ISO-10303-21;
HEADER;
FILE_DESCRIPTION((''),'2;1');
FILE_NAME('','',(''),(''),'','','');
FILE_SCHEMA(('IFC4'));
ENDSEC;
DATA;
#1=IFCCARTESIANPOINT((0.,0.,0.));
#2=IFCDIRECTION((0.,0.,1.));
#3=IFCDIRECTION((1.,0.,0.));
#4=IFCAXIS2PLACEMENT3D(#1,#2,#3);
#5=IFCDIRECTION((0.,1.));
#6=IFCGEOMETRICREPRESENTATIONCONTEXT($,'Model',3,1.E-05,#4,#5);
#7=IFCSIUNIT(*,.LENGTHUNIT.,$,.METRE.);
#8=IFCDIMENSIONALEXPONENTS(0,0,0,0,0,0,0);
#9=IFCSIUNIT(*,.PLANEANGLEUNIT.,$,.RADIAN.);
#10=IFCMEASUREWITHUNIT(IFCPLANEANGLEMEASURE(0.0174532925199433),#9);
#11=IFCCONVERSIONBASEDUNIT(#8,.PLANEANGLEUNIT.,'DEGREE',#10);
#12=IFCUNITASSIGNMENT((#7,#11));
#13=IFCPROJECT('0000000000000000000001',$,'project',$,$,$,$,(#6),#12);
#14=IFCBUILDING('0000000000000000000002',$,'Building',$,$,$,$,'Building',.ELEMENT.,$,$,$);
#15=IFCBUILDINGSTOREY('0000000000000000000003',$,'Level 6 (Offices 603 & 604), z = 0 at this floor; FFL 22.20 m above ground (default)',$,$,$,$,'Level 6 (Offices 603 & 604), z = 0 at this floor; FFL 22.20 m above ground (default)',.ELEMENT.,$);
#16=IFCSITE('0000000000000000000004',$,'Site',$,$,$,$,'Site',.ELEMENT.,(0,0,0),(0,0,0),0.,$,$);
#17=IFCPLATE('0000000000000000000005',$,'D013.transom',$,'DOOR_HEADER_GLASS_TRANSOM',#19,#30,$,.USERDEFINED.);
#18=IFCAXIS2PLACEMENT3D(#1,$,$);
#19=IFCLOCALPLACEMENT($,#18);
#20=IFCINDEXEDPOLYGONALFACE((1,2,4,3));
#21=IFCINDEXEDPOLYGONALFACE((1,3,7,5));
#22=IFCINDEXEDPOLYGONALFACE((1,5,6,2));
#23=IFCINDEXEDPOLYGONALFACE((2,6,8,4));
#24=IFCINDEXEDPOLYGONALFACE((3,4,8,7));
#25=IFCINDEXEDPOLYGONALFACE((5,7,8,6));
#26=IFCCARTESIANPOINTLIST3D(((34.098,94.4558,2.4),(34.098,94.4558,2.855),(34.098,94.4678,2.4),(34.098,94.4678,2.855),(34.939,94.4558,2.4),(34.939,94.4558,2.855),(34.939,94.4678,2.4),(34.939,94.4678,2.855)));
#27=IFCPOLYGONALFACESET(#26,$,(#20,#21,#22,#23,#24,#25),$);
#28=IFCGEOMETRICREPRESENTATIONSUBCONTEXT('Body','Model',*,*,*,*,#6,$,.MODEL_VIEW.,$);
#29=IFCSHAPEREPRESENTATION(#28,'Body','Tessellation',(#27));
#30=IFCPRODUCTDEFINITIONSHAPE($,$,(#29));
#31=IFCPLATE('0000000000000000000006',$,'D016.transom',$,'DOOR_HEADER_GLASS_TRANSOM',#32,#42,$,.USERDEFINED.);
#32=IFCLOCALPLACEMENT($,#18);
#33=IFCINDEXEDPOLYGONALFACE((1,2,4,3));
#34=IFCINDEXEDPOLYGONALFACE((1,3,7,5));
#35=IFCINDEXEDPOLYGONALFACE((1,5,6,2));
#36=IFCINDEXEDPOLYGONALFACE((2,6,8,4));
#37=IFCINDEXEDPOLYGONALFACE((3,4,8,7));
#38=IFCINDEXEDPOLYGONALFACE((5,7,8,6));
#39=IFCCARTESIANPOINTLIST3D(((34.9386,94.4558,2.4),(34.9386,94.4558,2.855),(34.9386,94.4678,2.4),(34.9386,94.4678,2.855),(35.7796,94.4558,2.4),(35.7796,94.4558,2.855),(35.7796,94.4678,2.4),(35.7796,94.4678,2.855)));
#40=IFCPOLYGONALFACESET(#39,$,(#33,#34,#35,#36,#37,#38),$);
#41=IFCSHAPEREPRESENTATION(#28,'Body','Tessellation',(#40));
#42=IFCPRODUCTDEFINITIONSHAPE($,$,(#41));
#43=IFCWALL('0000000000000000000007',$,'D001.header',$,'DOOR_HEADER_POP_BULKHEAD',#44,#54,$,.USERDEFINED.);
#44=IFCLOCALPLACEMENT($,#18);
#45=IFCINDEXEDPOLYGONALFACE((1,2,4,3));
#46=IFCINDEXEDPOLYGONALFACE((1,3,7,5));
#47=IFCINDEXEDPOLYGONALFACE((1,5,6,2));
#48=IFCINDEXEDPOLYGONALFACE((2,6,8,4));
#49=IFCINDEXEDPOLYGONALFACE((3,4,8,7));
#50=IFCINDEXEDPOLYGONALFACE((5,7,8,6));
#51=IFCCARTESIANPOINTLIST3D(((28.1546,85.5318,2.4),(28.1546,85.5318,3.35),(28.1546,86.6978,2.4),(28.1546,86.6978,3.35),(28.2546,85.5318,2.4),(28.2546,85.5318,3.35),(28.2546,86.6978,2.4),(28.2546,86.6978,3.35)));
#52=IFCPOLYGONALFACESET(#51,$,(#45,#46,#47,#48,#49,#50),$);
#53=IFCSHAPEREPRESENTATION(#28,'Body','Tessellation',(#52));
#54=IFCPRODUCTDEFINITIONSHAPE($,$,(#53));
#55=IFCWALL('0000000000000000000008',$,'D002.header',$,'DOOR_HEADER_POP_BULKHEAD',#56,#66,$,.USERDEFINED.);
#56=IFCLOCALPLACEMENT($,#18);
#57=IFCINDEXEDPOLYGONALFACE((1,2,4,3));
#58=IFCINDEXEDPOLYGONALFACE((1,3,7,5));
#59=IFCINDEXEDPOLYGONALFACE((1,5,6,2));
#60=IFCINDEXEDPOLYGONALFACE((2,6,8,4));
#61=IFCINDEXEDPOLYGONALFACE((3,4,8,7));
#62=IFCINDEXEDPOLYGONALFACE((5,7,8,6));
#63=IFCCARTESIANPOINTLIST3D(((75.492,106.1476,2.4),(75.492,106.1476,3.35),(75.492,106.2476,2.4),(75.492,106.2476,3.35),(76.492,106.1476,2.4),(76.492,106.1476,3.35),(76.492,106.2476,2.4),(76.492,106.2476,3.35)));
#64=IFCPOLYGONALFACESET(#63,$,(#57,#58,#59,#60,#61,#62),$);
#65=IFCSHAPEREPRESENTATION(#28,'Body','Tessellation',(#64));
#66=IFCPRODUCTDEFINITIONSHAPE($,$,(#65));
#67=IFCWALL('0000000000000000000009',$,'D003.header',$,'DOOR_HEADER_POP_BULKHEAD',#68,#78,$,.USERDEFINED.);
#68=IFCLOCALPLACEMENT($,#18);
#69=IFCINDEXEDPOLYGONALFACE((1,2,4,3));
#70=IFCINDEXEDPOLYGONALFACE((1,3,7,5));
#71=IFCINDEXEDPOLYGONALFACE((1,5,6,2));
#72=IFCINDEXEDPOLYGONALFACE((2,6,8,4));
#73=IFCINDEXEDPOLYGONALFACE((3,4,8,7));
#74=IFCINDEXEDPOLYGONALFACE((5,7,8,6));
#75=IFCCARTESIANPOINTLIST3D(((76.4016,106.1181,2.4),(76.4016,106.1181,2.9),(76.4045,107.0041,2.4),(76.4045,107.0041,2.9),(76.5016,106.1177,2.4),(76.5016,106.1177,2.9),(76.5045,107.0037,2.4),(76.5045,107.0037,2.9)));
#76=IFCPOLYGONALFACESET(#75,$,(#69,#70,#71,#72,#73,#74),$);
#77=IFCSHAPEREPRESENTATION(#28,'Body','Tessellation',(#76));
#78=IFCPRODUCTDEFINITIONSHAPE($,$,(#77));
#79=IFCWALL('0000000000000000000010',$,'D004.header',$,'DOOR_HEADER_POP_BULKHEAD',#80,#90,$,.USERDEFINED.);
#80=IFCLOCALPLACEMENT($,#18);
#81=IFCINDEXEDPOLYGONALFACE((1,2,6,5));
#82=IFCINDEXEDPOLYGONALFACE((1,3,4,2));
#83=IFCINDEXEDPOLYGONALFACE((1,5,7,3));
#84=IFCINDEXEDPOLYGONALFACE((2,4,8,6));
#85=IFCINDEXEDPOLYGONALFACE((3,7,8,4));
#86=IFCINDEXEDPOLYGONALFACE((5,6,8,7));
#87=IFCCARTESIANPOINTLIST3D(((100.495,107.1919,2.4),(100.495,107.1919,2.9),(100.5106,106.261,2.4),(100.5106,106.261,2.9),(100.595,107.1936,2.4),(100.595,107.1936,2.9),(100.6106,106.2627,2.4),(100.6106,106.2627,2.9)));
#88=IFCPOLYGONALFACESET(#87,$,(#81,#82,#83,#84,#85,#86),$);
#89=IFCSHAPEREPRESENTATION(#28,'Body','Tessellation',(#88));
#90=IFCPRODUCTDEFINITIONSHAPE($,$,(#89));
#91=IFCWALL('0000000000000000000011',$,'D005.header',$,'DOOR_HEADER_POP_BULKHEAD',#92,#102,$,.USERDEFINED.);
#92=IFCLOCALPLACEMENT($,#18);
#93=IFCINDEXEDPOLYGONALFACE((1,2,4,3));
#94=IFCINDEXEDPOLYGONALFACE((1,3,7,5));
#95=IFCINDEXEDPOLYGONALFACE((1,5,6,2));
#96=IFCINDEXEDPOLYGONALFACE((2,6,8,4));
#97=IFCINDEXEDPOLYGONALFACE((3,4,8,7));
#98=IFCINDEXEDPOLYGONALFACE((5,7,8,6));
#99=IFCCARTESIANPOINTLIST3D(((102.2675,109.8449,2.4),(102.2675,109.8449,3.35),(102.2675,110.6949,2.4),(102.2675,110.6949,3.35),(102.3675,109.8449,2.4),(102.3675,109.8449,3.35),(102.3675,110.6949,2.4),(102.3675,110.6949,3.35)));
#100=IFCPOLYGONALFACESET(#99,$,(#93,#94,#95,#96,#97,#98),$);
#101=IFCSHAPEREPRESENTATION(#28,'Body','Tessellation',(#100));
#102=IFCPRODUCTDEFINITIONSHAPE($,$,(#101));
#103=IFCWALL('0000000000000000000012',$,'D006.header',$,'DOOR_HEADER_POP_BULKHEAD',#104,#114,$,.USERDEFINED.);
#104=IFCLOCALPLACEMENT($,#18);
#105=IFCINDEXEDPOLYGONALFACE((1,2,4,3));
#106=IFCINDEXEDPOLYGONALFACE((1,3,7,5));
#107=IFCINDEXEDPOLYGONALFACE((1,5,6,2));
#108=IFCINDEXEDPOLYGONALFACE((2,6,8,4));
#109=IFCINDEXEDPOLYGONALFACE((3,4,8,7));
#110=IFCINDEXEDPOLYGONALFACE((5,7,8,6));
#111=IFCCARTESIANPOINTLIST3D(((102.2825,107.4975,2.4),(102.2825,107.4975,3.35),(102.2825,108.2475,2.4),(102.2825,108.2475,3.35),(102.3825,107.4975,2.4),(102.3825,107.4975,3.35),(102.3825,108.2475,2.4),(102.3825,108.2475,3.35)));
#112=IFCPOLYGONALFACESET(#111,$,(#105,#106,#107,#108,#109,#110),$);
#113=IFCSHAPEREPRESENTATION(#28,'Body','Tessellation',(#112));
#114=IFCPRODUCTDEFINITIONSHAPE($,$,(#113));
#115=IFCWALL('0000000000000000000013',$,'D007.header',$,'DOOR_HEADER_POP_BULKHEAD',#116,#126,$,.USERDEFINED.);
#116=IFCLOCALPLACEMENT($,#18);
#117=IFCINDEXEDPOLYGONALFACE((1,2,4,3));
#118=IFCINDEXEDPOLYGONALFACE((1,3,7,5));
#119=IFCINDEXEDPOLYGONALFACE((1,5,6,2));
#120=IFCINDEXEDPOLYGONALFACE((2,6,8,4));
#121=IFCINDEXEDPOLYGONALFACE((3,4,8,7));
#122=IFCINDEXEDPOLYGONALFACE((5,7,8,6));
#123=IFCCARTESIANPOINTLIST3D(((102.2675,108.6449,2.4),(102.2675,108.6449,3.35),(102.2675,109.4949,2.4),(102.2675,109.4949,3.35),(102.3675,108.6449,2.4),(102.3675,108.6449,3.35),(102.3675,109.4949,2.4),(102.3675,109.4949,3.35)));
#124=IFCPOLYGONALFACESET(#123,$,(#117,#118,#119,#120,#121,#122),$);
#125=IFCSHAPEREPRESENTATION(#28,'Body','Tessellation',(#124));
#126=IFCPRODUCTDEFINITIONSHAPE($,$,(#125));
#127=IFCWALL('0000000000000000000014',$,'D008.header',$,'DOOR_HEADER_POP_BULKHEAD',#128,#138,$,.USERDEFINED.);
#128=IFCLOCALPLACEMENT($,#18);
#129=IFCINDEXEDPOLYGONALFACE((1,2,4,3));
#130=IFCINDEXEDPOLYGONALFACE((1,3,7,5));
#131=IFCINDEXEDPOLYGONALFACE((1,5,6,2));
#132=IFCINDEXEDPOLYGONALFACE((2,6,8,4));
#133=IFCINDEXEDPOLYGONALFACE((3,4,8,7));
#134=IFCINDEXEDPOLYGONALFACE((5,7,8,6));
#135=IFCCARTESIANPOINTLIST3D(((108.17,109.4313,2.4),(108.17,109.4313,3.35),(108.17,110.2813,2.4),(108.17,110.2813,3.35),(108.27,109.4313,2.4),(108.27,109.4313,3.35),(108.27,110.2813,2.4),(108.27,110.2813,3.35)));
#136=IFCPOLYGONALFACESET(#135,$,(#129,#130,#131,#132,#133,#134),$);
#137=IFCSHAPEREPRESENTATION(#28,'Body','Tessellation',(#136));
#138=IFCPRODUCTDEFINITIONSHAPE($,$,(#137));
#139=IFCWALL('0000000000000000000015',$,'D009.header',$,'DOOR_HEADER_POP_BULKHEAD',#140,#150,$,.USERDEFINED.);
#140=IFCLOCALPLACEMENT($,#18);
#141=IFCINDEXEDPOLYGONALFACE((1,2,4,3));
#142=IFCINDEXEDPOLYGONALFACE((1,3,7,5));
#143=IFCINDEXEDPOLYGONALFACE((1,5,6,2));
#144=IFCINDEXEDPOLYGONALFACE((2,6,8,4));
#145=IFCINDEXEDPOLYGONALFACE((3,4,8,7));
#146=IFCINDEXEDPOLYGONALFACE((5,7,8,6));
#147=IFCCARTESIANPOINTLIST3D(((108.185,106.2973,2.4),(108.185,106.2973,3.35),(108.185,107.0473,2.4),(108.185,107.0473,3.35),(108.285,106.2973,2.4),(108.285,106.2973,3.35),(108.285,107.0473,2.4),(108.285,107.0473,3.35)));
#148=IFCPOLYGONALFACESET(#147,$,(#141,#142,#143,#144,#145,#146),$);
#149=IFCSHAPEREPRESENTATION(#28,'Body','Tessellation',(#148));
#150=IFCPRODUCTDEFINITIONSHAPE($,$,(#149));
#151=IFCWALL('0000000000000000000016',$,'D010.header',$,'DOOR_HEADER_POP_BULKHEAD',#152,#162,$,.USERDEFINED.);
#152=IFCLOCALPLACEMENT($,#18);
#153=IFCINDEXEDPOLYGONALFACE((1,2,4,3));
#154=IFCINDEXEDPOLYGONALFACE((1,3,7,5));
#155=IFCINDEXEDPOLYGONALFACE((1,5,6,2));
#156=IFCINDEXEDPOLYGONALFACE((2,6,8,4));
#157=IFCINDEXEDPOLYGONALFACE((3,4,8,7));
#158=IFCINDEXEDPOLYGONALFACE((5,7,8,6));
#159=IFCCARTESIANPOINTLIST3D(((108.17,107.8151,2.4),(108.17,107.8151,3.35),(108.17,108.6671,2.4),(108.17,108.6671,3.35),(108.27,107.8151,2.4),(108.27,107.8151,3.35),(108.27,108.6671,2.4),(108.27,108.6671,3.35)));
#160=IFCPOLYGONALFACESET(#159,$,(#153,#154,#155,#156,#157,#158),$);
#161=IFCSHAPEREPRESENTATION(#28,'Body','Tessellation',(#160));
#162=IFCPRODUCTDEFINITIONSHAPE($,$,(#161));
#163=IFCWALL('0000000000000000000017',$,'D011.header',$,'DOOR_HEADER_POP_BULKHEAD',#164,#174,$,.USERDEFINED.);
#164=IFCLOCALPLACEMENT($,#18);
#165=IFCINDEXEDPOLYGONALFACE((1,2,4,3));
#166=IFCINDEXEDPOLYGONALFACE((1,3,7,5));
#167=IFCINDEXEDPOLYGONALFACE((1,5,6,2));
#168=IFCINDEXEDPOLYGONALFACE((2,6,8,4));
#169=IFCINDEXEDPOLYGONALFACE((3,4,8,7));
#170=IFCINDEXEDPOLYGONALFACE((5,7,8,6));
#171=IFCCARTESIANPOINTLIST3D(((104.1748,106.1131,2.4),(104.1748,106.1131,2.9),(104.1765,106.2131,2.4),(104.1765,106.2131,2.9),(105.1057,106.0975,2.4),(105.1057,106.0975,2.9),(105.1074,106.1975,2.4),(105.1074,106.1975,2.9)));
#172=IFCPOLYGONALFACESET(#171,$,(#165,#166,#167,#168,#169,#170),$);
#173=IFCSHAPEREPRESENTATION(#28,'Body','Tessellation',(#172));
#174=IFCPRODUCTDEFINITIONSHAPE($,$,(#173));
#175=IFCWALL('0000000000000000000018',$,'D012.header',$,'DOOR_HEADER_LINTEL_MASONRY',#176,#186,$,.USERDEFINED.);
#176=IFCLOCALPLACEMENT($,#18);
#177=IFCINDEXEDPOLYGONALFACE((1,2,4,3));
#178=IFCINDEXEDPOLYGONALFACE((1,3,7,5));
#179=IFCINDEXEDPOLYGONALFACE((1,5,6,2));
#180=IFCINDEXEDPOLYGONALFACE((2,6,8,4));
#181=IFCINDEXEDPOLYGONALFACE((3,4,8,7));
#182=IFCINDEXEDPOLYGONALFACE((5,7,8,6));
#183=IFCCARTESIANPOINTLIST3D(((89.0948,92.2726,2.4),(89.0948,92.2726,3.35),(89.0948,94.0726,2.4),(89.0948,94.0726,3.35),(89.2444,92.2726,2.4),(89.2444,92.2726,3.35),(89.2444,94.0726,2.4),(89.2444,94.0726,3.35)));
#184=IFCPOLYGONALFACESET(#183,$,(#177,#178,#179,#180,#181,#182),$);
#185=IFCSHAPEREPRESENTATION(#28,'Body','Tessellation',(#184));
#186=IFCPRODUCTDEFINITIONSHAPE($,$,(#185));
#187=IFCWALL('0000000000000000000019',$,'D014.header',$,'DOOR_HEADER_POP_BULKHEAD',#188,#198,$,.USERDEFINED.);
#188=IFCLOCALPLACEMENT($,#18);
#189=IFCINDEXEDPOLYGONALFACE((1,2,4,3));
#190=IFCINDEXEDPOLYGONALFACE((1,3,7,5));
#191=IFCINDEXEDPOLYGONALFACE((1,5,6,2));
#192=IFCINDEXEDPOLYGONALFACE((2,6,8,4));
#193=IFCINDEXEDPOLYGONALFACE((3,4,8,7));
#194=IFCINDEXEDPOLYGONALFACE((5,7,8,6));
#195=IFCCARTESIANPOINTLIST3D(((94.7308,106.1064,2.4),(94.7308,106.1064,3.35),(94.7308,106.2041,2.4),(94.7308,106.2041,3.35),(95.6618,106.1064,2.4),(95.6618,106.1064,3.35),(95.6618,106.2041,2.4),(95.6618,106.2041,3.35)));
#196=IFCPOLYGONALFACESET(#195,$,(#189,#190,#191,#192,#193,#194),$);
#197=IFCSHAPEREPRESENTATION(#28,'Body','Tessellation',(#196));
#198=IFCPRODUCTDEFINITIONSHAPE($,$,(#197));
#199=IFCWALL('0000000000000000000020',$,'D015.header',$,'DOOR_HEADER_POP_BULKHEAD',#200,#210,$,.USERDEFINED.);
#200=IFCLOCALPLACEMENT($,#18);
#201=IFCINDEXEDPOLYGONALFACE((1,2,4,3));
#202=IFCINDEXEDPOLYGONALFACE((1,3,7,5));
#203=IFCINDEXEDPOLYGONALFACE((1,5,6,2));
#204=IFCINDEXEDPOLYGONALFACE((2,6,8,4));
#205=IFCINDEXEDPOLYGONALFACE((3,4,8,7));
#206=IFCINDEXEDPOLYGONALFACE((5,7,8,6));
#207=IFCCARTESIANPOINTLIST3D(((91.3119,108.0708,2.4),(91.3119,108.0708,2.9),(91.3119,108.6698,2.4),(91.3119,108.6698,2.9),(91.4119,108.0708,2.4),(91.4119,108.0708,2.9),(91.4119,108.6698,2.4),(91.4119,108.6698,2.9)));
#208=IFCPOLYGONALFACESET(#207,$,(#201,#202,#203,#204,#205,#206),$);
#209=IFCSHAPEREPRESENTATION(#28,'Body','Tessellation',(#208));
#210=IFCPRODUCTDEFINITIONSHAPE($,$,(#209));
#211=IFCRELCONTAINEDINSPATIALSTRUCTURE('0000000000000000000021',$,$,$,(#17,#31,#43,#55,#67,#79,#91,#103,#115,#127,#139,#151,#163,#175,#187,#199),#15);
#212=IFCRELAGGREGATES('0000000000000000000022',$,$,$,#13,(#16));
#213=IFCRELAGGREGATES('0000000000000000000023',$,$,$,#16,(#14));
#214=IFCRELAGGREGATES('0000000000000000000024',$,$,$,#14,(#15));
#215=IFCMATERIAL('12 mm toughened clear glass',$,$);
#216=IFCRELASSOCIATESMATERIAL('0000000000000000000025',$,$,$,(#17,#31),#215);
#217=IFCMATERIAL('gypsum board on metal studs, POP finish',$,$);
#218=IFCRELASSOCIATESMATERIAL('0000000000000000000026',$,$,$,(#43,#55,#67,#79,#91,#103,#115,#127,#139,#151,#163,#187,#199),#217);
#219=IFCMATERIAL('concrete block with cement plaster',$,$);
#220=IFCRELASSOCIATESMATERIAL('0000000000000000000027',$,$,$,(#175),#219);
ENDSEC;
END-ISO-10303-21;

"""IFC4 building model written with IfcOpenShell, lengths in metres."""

from ifc_helpers import new_model, entity, si_unit, converted_unit, direction, frame, frame_2d, origin_with_axes, origin_2d_with_axis, place, context, subcontext, project, spatial, rectangle, extrude, material, element, save


model = new_model("IFC4")

# Units and contexts
model_context = context("Model", 3, precision=1e-05, world=origin_with_axes(), true_north=direction((0.0, 1.0)))
body_context = subcontext(model_context, "Body", "Model", "MODEL_VIEW")
ifc_project = project(units=[si_unit("LENGTHUNIT", "METRE"), converted_unit("PLANEANGLEUNIT", "DEGREE", entity("IfcPlaneAngleMeasure", 0.0174532925199433), si_unit("PLANEANGLEUNIT", "RADIAN"), dimensions=[0, 0, 0, 0, 0, 0, 0])], contexts=[model_context])

# Site, building, storey
site = spatial("IfcSite", under=ifc_project, Name="Site", LongName="Site", CompositionType="ELEMENT", RefLatitude=(0, 0, 0), RefLongitude=(0, 0, 0), RefElevation=0.0)
building = spatial("IfcBuilding", under=site, Name="Building", LongName="Building", CompositionType="ELEMENT")
storey = spatial("IfcBuildingStorey", under=building, Name="Level 6 (Offices 603 & 604), z = 0 at this floor; FFL 22.20 m above ground (default)", LongName="Level 6 (Offices 603 & 604), z = 0 at this floor; FFL 22.20 m above ground (default)", CompositionType="ELEMENT")

# Plates
ifc_material_1 = material(Name="12 mm toughened clear glass")
placement = place(None, origin_with_axes())
element("IfcPlate", 1, at=placement, inside=storey, material=ifc_material_1, Name="D013.transom", ObjectType="DOOR_HEADER_GLASS_TRANSOM", PredefinedType="USERDEFINED", context=body_context, shape_type="SweptSolid", body=[
    extrude(rectangle(XDim=0.841, YDim=0.012, at=frame_2d((0.0, 0.0), x_axis=(1.0, 0.0))), frame((34.5185, 94.4618, 2.4), z_axis=(0.0, 0.0, 1.0), x_axis=(1.0, 0.0, 0.0)), (0.0, 0.0, 1.0), 0.455),
])
element("IfcPlate", 2, at=placement, inside=storey, material=ifc_material_1, Name="D016.transom", ObjectType="DOOR_HEADER_GLASS_TRANSOM", PredefinedType="USERDEFINED", context=body_context, shape_type="SweptSolid", body=[
    extrude(rectangle(XDim=0.841, YDim=0.012, at=frame_2d((0.0, 0.0), x_axis=(1.0, 0.0))), frame((35.3591, 94.4618, 2.4), z_axis=(0.0, 0.0, 1.0), x_axis=(1.0, 0.0, 0.0)), (0.0, 0.0, 1.0), 0.455),
])

# Walls
ifc_material_2 = material(Name="gypsum board on metal studs, POP finish")
element("IfcWall", 3, at=placement, inside=storey, material=ifc_material_2, Name="D001.header", ObjectType="DOOR_HEADER_POP_BULKHEAD", PredefinedType="USERDEFINED", context=body_context, shape_type="SweptSolid", body=[
    extrude(rectangle(XDim=1.166, YDim=0.1, at=frame_2d((0.0, 0.0), x_axis=(0.0, 1.0))), frame((28.2046, 86.1148, 2.4), z_axis=(0.0, 0.0, 1.0), x_axis=(1.0, 0.0, 0.0)), (0.0, 0.0, 1.0), 0.95),
])
element("IfcWall", 4, at=placement, inside=storey, material=ifc_material_2, Name="D002.header", ObjectType="DOOR_HEADER_POP_BULKHEAD", PredefinedType="USERDEFINED", context=body_context, shape_type="SweptSolid", body=[
    extrude(rectangle(XDim=1.0, YDim=0.1, at=origin_2d_with_axis()), frame((75.992, 106.1976, 2.4), z_axis=(0.0, 0.0, 1.0), x_axis=(1.0, 0.0, 0.0)), (0.0, 0.0, 1.0), 0.95),
])
element("IfcWall", 5, at=placement, inside=storey, material=ifc_material_2, Name="D003.header", ObjectType="DOOR_HEADER_POP_BULKHEAD", PredefinedType="USERDEFINED", context=body_context, shape_type="SweptSolid", body=[
    extrude(rectangle(XDim=0.886, YDim=0.1, at=frame_2d((0.0, 0.0), x_axis=(0.003275, 0.999995))), frame((76.4531, 106.5609, 2.4), z_axis=(0.0, 0.0, 1.0), x_axis=(1.0, 0.0, 0.0)), (0.0, 0.0, 1.0), 0.5),
])
element("IfcWall", 6, at=placement, inside=storey, material=ifc_material_2, Name="D004.header", ObjectType="DOOR_HEADER_POP_BULKHEAD", PredefinedType="USERDEFINED", context=body_context, shape_type="SweptSolid", body=[
    extrude(rectangle(XDim=0.931, YDim=0.1, at=frame_2d((0.0, 0.0), x_axis=(0.016765, -0.999859))), frame((100.5528, 106.7273, 2.4), z_axis=(0.0, 0.0, 1.0), x_axis=(1.0, 0.0, 0.0)), (0.0, 0.0, 1.0), 0.5),
])
element("IfcWall", 7, at=placement, inside=storey, material=ifc_material_2, Name="D005.header", ObjectType="DOOR_HEADER_POP_BULKHEAD", PredefinedType="USERDEFINED", context=body_context, shape_type="SweptSolid", body=[
    extrude(rectangle(XDim=0.85, YDim=0.1, at=frame_2d((0.0, 0.0), x_axis=(0.0, 1.0))), frame((102.3175, 110.2699, 2.4), z_axis=(0.0, 0.0, 1.0), x_axis=(1.0, 0.0, 0.0)), (0.0, 0.0, 1.0), 0.95),
])
element("IfcWall", 8, at=placement, inside=storey, material=ifc_material_2, Name="D006.header", ObjectType="DOOR_HEADER_POP_BULKHEAD", PredefinedType="USERDEFINED", context=body_context, shape_type="SweptSolid", body=[
    extrude(rectangle(XDim=0.75, YDim=0.1, at=frame_2d((0.0, 0.0), x_axis=(0.0, 1.0))), frame((102.3325, 107.8725, 2.4), z_axis=(0.0, 0.0, 1.0), x_axis=(1.0, 0.0, 0.0)), (0.0, 0.0, 1.0), 0.95),
])
element("IfcWall", 9, at=placement, inside=storey, material=ifc_material_2, Name="D007.header", ObjectType="DOOR_HEADER_POP_BULKHEAD", PredefinedType="USERDEFINED", context=body_context, shape_type="SweptSolid", body=[
    extrude(rectangle(XDim=0.85, YDim=0.1, at=frame_2d((0.0, 0.0), x_axis=(0.0, 1.0))), frame((102.3175, 109.0699, 2.4), z_axis=(0.0, 0.0, 1.0), x_axis=(1.0, 0.0, 0.0)), (0.0, 0.0, 1.0), 0.95),
])
element("IfcWall", 10, at=placement, inside=storey, material=ifc_material_2, Name="D008.header", ObjectType="DOOR_HEADER_POP_BULKHEAD", PredefinedType="USERDEFINED", context=body_context, shape_type="SweptSolid", body=[
    extrude(rectangle(XDim=0.85, YDim=0.1, at=frame_2d((0.0, 0.0), x_axis=(0.0, 1.0))), frame((108.22, 109.8563, 2.4), z_axis=(0.0, 0.0, 1.0), x_axis=(1.0, 0.0, 0.0)), (0.0, 0.0, 1.0), 0.95),
])
element("IfcWall", 11, at=placement, inside=storey, material=ifc_material_2, Name="D009.header", ObjectType="DOOR_HEADER_POP_BULKHEAD", PredefinedType="USERDEFINED", context=body_context, shape_type="SweptSolid", body=[
    extrude(rectangle(XDim=0.75, YDim=0.1, at=frame_2d((0.0, 0.0), x_axis=(0.0, 1.0))), frame((108.235, 106.6723, 2.4), z_axis=(0.0, 0.0, 1.0), x_axis=(1.0, 0.0, 0.0)), (0.0, 0.0, 1.0), 0.95),
])
element("IfcWall", 12, at=placement, inside=storey, material=ifc_material_2, Name="D010.header", ObjectType="DOOR_HEADER_POP_BULKHEAD", PredefinedType="USERDEFINED", context=body_context, shape_type="SweptSolid", body=[
    extrude(rectangle(XDim=0.852, YDim=0.1, at=frame_2d((0.0, 0.0), x_axis=(0.0, 1.0))), frame((108.22, 108.2411, 2.4), z_axis=(0.0, 0.0, 1.0), x_axis=(1.0, 0.0, 0.0)), (0.0, 0.0, 1.0), 0.95),
])
element("IfcWall", 13, at=placement, inside=storey, material=ifc_material_2, Name="D011.header", ObjectType="DOOR_HEADER_POP_BULKHEAD", PredefinedType="USERDEFINED", context=body_context, shape_type="SweptSolid", body=[
    extrude(rectangle(XDim=0.931, YDim=0.1, at=frame_2d((0.0, 0.0), x_axis=(0.999859, -0.016765))), frame((104.6411, 106.1553, 2.4), z_axis=(0.0, 0.0, 1.0), x_axis=(1.0, 0.0, 0.0)), (0.0, 0.0, 1.0), 0.5),
])
ifc_material_3 = material(Name="concrete block with cement plaster")
element("IfcWall", 14, at=placement, inside=storey, material=ifc_material_3, Name="D012.header", ObjectType="DOOR_HEADER_LINTEL_MASONRY", PredefinedType="USERDEFINED", context=body_context, shape_type="SweptSolid", body=[
    extrude(rectangle(XDim=1.8, YDim=0.1496, at=frame_2d((0.0, 0.0), x_axis=(0.0, 1.0))), frame((89.1696, 93.1726, 2.4), z_axis=(0.0, 0.0, 1.0), x_axis=(1.0, 0.0, 0.0)), (0.0, 0.0, 1.0), 0.95),
])
element("IfcWall", 15, at=placement, inside=storey, material=ifc_material_2, Name="D014.header", ObjectType="DOOR_HEADER_POP_BULKHEAD", PredefinedType="USERDEFINED", context=body_context, shape_type="SweptSolid", body=[
    extrude(rectangle(XDim=0.931, YDim=0.0977, at=frame_2d((0.0, 0.0), x_axis=(1.0, 0.0))), frame((95.1963, 106.1553, 2.4), z_axis=(0.0, 0.0, 1.0), x_axis=(1.0, 0.0, 0.0)), (0.0, 0.0, 1.0), 0.95),
])
element("IfcWall", 16, at=placement, inside=storey, material=ifc_material_2, Name="D015.header", ObjectType="DOOR_HEADER_POP_BULKHEAD", PredefinedType="USERDEFINED", context=body_context, shape_type="SweptSolid", body=[
    extrude(rectangle(XDim=0.599, YDim=0.1, at=frame_2d((0.0, 0.0), x_axis=(0.0, 1.0))), frame((91.3619, 108.3704, 2.4), z_axis=(0.0, 0.0, 1.0), x_axis=(1.0, 0.0, 0.0)), (0.0, 0.0, 1.0), 0.5),
])

save(model, "model.ifc")
